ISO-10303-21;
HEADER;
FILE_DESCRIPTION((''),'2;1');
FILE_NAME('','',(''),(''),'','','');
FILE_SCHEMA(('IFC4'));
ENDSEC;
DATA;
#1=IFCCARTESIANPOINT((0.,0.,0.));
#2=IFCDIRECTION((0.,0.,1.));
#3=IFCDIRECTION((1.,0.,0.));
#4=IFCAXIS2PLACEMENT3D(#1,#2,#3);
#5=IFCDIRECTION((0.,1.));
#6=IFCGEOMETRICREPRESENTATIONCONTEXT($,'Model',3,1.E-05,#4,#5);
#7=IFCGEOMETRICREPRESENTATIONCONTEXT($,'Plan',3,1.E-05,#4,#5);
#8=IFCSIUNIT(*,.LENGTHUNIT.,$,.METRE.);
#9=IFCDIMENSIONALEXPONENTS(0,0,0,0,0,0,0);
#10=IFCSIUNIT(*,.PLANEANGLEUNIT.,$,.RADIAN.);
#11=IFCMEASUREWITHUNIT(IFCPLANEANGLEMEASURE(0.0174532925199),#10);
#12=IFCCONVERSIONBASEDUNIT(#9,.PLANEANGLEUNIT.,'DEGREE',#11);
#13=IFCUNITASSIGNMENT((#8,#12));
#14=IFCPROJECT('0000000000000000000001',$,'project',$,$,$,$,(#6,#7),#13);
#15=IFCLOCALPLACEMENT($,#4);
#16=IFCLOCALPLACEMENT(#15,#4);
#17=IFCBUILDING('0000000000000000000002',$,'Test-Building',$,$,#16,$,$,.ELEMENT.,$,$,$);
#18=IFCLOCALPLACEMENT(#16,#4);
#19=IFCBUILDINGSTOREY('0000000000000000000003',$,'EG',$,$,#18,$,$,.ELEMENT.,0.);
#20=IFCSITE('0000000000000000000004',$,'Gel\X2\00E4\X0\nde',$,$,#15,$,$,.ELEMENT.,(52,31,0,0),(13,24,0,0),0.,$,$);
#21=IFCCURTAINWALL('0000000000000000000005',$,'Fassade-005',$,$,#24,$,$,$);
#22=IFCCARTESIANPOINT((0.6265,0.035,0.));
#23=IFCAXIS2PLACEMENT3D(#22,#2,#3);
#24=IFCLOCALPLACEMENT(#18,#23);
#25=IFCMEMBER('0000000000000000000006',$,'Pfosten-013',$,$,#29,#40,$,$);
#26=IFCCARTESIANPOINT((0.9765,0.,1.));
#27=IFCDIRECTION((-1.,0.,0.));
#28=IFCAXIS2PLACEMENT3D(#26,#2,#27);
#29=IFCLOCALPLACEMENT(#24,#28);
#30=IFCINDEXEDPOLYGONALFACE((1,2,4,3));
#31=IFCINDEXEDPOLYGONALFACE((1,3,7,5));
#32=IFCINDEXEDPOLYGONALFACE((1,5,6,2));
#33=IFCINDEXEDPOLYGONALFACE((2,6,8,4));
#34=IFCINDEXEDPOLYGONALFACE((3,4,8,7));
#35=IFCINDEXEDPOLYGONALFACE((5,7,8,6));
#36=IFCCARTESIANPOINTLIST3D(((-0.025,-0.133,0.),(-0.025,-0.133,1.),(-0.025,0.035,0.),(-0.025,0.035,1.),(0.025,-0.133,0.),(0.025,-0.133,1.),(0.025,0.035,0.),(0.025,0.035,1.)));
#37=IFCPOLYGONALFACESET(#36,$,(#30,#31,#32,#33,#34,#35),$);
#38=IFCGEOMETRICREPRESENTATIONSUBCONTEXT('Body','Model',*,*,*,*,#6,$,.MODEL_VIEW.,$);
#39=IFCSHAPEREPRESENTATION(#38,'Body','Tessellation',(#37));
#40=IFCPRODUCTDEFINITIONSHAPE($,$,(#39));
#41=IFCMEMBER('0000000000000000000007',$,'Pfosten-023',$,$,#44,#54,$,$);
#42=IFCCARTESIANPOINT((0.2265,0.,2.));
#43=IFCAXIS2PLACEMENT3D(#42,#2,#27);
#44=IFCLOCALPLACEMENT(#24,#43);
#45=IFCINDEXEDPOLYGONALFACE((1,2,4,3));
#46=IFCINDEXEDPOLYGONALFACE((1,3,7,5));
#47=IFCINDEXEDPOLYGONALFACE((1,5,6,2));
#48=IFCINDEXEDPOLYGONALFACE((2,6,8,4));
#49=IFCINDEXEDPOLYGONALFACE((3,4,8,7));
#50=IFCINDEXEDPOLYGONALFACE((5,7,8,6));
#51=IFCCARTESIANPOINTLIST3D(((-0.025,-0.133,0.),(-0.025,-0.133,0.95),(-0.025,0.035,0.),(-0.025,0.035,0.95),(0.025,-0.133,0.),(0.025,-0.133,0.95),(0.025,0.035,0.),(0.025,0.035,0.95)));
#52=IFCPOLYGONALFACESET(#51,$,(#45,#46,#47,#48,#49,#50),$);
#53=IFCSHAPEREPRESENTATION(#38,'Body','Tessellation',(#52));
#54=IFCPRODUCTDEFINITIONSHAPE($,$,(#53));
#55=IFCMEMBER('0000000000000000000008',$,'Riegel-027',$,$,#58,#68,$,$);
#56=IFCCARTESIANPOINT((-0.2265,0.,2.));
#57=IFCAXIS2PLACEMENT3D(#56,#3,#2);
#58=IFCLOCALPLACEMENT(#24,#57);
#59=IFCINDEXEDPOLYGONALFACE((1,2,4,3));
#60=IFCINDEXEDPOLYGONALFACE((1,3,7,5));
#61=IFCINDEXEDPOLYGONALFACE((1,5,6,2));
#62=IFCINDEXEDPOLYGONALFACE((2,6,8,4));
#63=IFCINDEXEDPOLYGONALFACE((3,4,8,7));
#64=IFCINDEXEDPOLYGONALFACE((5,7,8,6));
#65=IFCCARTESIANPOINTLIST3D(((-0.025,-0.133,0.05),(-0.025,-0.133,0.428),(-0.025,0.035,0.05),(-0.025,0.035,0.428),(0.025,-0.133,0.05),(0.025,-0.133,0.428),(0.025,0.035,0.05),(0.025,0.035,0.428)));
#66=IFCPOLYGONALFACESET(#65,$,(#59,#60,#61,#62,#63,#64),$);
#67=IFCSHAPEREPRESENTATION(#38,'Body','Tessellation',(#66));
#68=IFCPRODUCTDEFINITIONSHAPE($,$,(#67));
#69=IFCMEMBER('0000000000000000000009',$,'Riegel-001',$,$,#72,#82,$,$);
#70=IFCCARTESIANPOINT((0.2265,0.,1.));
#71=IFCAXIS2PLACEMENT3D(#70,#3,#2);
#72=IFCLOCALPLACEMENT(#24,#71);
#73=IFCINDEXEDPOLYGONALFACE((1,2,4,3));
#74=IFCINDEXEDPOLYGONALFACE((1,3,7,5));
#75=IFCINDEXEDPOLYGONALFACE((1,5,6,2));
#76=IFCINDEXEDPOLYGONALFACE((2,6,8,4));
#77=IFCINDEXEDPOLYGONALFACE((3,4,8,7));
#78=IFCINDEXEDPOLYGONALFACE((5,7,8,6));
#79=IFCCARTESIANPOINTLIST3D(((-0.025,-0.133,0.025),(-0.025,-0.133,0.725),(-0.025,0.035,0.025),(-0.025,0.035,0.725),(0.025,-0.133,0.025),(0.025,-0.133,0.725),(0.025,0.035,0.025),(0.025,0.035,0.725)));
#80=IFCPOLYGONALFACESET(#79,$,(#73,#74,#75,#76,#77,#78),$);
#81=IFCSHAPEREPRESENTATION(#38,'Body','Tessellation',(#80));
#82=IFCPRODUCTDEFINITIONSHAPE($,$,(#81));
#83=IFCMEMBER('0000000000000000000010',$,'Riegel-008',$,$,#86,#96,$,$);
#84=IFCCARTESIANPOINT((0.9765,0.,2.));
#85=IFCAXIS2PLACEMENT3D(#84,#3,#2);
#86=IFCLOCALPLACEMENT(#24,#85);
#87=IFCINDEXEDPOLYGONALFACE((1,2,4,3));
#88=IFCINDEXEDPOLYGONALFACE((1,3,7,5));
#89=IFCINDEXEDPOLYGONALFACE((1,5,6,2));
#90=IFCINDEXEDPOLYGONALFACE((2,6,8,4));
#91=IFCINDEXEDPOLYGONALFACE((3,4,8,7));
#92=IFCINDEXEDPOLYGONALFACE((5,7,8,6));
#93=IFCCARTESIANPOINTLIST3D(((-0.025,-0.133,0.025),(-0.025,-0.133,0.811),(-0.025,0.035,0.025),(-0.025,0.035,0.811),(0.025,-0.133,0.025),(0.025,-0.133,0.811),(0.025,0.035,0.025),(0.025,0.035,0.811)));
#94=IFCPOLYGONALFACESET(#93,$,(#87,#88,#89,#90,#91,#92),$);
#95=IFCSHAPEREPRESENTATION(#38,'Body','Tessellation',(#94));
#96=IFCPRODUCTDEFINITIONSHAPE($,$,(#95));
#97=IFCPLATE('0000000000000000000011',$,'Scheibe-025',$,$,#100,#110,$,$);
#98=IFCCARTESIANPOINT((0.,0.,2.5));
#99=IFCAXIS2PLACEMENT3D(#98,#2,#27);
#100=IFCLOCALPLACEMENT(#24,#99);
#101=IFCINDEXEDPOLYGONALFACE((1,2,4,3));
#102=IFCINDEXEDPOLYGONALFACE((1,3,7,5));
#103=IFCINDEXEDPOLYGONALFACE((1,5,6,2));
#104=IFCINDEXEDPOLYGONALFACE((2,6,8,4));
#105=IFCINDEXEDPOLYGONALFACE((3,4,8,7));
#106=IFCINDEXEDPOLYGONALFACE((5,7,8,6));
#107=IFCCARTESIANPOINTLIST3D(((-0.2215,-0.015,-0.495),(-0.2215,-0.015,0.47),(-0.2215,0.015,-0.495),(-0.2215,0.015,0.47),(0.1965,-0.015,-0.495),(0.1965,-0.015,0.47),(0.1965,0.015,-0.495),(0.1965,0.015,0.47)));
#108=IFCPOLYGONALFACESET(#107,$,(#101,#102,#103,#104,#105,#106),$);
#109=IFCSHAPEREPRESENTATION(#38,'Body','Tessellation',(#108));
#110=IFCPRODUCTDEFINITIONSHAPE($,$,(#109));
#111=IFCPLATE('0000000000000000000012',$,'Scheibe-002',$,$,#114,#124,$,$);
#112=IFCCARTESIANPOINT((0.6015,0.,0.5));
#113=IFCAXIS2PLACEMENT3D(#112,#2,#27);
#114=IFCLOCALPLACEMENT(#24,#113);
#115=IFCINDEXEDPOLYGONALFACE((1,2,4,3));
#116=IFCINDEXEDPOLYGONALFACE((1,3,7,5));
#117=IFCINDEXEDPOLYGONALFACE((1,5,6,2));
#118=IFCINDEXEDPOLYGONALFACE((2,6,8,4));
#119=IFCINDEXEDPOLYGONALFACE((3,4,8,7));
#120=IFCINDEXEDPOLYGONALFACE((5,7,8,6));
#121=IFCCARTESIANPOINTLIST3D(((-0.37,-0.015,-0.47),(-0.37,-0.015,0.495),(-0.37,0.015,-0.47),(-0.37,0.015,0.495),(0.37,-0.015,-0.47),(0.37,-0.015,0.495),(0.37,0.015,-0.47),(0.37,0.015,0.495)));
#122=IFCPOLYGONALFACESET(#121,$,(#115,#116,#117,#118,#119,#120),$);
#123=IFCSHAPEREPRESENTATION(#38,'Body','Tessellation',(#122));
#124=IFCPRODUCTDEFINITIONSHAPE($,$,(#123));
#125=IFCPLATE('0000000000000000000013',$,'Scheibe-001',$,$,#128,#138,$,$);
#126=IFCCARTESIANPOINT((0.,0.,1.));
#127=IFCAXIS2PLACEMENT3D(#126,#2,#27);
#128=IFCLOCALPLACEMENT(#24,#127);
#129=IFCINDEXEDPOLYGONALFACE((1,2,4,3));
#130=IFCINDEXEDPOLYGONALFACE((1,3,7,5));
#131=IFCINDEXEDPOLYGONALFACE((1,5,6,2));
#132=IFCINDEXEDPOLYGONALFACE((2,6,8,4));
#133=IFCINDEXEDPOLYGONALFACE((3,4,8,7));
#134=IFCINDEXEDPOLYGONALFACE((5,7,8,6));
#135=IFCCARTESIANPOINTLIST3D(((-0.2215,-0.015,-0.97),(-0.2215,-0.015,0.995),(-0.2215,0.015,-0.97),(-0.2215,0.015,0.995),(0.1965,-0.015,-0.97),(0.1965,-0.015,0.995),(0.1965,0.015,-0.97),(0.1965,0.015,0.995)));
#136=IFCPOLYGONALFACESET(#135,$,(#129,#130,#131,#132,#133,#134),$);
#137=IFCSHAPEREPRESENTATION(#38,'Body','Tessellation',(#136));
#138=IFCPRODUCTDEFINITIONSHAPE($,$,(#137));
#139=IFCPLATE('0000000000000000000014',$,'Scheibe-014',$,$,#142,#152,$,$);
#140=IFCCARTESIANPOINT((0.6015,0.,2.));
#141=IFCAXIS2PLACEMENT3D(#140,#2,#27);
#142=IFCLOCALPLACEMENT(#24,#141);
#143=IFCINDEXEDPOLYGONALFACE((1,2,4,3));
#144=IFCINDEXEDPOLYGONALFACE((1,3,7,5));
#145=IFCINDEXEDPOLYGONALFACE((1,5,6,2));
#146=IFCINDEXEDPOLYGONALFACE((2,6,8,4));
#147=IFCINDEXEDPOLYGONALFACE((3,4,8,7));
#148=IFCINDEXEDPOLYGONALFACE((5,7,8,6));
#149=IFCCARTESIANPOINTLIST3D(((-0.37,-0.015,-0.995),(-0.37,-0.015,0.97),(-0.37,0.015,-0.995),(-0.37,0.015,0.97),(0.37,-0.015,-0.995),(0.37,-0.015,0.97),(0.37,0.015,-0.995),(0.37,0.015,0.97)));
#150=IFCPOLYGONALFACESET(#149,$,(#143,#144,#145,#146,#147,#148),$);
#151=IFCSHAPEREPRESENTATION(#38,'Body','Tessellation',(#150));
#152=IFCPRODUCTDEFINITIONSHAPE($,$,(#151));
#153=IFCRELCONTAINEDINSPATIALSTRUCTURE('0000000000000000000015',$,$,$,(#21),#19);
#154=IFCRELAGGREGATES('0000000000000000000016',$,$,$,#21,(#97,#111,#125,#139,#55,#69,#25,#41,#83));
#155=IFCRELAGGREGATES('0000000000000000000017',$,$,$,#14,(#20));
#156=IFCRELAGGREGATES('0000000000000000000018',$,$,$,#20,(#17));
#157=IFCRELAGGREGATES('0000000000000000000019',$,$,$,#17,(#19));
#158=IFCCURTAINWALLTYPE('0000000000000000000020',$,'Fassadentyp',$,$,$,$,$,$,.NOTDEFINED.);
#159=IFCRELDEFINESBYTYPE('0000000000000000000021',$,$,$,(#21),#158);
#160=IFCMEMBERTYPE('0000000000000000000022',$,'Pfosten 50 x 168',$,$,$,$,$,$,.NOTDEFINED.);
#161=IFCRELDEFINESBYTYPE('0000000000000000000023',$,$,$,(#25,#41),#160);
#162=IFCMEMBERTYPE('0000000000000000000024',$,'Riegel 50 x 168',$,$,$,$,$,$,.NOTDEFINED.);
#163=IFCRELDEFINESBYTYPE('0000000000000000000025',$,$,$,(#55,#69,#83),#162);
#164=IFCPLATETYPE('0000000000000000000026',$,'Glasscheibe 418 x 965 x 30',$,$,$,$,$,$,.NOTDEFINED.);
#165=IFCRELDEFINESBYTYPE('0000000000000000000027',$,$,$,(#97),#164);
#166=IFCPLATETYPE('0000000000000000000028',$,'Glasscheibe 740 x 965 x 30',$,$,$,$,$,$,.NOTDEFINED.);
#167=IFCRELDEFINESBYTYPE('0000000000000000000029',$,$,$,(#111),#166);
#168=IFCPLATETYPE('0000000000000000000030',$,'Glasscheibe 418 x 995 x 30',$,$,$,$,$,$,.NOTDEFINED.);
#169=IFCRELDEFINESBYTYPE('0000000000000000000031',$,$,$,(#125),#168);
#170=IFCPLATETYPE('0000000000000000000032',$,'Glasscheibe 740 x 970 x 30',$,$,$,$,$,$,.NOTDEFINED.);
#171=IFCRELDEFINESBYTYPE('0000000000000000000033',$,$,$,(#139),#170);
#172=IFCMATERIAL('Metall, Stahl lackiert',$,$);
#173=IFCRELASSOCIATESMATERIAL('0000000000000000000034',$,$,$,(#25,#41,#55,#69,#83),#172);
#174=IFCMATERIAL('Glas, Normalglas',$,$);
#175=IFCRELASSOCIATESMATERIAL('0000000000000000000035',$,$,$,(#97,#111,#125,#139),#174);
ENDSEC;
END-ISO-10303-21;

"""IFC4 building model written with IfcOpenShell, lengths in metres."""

from ifc_helpers import new_model, entity, si_unit, converted_unit, direction, frame, origin_with_axes, place, context, subcontext, project, spatial, polyline, outline, extrude, material, type_object, element, aggregate, save


model = new_model("IFC4")

# Units and contexts
model_context = context("Model", 3, precision=1e-05, world=origin_with_axes(), true_north=direction((0.0, 1.0)))
plan_context = context("Plan", 3, precision=1e-05, world=origin_with_axes(), true_north=direction((0.0, 1.0)))
body_context = subcontext(model_context, "Body", "Model", "MODEL_VIEW")
ifc_project = project(units=[si_unit("LENGTHUNIT", "METRE"), converted_unit("PLANEANGLEUNIT", "DEGREE", entity("IfcPlaneAngleMeasure", 0.0174532925199), si_unit("PLANEANGLEUNIT", "RADIAN"), dimensions=[0, 0, 0, 0, 0, 0, 0])], contexts=[model_context, plan_context])

# Site, building, storey
site_placement = place(None, origin_with_axes())
site = spatial("IfcSite", under=ifc_project, at=site_placement, Name="Gelände", CompositionType="ELEMENT", RefLatitude=(52, 31, 0, 0), RefLongitude=(13, 24, 0, 0), RefElevation=0.0)
building_placement = place(site_placement, origin_with_axes())
building = spatial("IfcBuilding", under=site, at=building_placement, Name="Test-Building", CompositionType="ELEMENT")
storey_placement = place(building_placement, origin_with_axes())
storey = spatial("IfcBuildingStorey", under=building, at=storey_placement, Name="EG", CompositionType="ELEMENT", Elevation=0.0)

# Curtain wall, members, plates
curtain_wall_type = type_object("IfcCurtainWallType", Name="Fassadentyp", PredefinedType="NOTDEFINED")
curtain_wall_placement = place(storey_placement, frame((0.6265, 0.035, 0.0), z_axis=(0.0, 0.0, 1.0), x_axis=(1.0, 0.0, 0.0)))
curtain_wall = element("IfcCurtainWall", 1, at=curtain_wall_placement, inside=storey, type_object=curtain_wall_type, Name="Fassade-005")
ifc_material_1 = material(Name="Metall, Stahl lackiert")
member_type_1 = type_object("IfcMemberType", Name="Pfosten 50 x 168", PredefinedType="NOTDEFINED")
member_1_placement = place(curtain_wall_placement, frame((0.9765, 0.0, 1.0), z_axis=(0.0, 0.0, 1.0), x_axis=(-1.0, 0.0, 0.0)))
member_1 = element("IfcMember", 2, at=member_1_placement, type_object=member_type_1, material=ifc_material_1, Name="Pfosten-013", context=body_context, shape_type="SweptSolid", body=[
    extrude(outline(polyline([(-0.025, 0.133), (-0.025, -0.035), (0.025, -0.035), (0.025, 0.133), (-0.025, 0.133)])), frame((0.0, 0.0, 0.0), z_axis=(0.0, 0.0, 1.0), x_axis=(-1.0, 0.0, 0.0)), (0.0, 0.0, 1.0), 1.0),
])
member_2_placement = place(curtain_wall_placement, frame((0.2265, 0.0, 2.0), z_axis=(0.0, 0.0, 1.0), x_axis=(-1.0, 0.0, 0.0)))
member_2 = element("IfcMember", 3, at=member_2_placement, type_object=member_type_1, material=ifc_material_1, Name="Pfosten-023", context=body_context, shape_type="SweptSolid", body=[
    extrude(outline(polyline([(-0.025, 0.133), (-0.025, -0.035), (0.025, -0.035), (0.025, 0.133), (-0.025, 0.133)])), frame((0.0, 0.0, 0.0), z_axis=(0.0, 0.0, 1.0), x_axis=(-1.0, 0.0, 0.0)), (0.0, 0.0, 1.0), 0.95),
])
member_type_2 = type_object("IfcMemberType", Name="Riegel 50 x 168", PredefinedType="NOTDEFINED")
member_3_placement = place(curtain_wall_placement, frame((-0.2265, 0.0, 2.0), z_axis=(1.0, 0.0, 0.0), x_axis=(0.0, 0.0, 1.0)))
member_3 = element("IfcMember", 4, at=member_3_placement, type_object=member_type_2, material=ifc_material_1, Name="Riegel-027", context=body_context, shape_type="SweptSolid", body=[
    extrude(outline(polyline([(-0.133, -0.025), (0.035, -0.025), (0.035, 0.025), (-0.133, 0.025), (-0.133, -0.025)])), frame((0.0, 0.0, 0.05), z_axis=(0.0, 0.0, 1.0), x_axis=(0.0, 1.0, 0.0)), (0.0, 0.0, 1.0), 0.378),
])
member_4_placement = place(curtain_wall_placement, frame((0.2265, 0.0, 1.0), z_axis=(1.0, 0.0, 0.0), x_axis=(0.0, 0.0, 1.0)))
member_4 = element("IfcMember", 5, at=member_4_placement, type_object=member_type_2, material=ifc_material_1, Name="Riegel-001", context=body_context, shape_type="SweptSolid", body=[
    extrude(outline(polyline([(-0.133, -0.025), (0.035, -0.025), (0.035, 0.025), (-0.133, 0.025), (-0.133, -0.025)])), frame((0.0, 0.0, 0.025), z_axis=(0.0, 0.0, 1.0), x_axis=(0.0, 1.0, 0.0)), (0.0, 0.0, 1.0), 0.7),
])
member_5_placement = place(curtain_wall_placement, frame((0.9765, 0.0, 2.0), z_axis=(1.0, 0.0, 0.0), x_axis=(0.0, 0.0, 1.0)))
member_5 = element("IfcMember", 6, at=member_5_placement, type_object=member_type_2, material=ifc_material_1, Name="Riegel-008", context=body_context, shape_type="SweptSolid", body=[
    extrude(outline(polyline([(-0.133, -0.025), (0.035, -0.025), (0.035, 0.025), (-0.133, 0.025), (-0.133, -0.025)])), frame((0.0, 0.0, 0.025), z_axis=(0.0, 0.0, 1.0), x_axis=(0.0, 1.0, 0.0)), (0.0, 0.0, 1.0), 0.786),
])
ifc_material_2 = material(Name="Glas, Normalglas")
plate_type_1 = type_object("IfcPlateType", Name="Glasscheibe 418 x 965 x 30", PredefinedType="NOTDEFINED")
plate_1_placement = place(curtain_wall_placement, frame((0.0, 0.0, 2.5), z_axis=(0.0, 0.0, 1.0), x_axis=(-1.0, 0.0, 0.0)))
plate_1 = element("IfcPlate", 7, at=plate_1_placement, type_object=plate_type_1, material=ifc_material_2, Name="Scheibe-025", context=body_context, shape_type="SweptSolid", body=[
    extrude(outline(polyline([(-0.2215, -0.47), (0.1965, -0.47), (0.1965, 0.495), (-0.2215, 0.495), (-0.2215, -0.47)])), frame((0.0, -0.015, 0.0), z_axis=(0.0, 1.0, 0.0), x_axis=(1.0, 0.0, 0.0)), (0.0, 0.0, 1.0), 0.03),
])
plate_type_2 = type_object("IfcPlateType", Name="Glasscheibe 740 x 965 x 30", PredefinedType="NOTDEFINED")
plate_2_placement = place(curtain_wall_placement, frame((0.6015, 0.0, 0.5), z_axis=(0.0, 0.0, 1.0), x_axis=(-1.0, 0.0, 0.0)))
plate_2 = element("IfcPlate", 8, at=plate_2_placement, type_object=plate_type_2, material=ifc_material_2, Name="Scheibe-002", context=body_context, shape_type="SweptSolid", body=[
    extrude(outline(polyline([(-0.37, -0.495), (0.37, -0.495), (0.37, 0.47), (-0.37, 0.47), (-0.37, -0.495)])), frame((0.0, -0.015, 0.0), z_axis=(0.0, 1.0, 0.0), x_axis=(1.0, 0.0, 0.0)), (0.0, 0.0, 1.0), 0.03),
])
plate_type_3 = type_object("IfcPlateType", Name="Glasscheibe 418 x 995 x 30", PredefinedType="NOTDEFINED")
plate_3_placement = place(curtain_wall_placement, frame((0.0, 0.0, 1.0), z_axis=(0.0, 0.0, 1.0), x_axis=(-1.0, 0.0, 0.0)))
plate_3 = element("IfcPlate", 9, at=plate_3_placement, type_object=plate_type_3, material=ifc_material_2, Name="Scheibe-001", context=body_context, shape_type="SweptSolid", body=[
    extrude(outline(polyline([(-0.2215, -0.995), (0.1965, -0.995), (0.1965, 0.97), (-0.2215, 0.97), (-0.2215, -0.995)])), frame((0.0, -0.015, 0.0), z_axis=(0.0, 1.0, 0.0), x_axis=(1.0, 0.0, 0.0)), (0.0, 0.0, 1.0), 0.03),
])
plate_type_4 = type_object("IfcPlateType", Name="Glasscheibe 740 x 970 x 30", PredefinedType="NOTDEFINED")
plate_4_placement = place(curtain_wall_placement, frame((0.6015, 0.0, 2.0), z_axis=(0.0, 0.0, 1.0), x_axis=(-1.0, 0.0, 0.0)))
plate_4 = element("IfcPlate", 10, at=plate_4_placement, type_object=plate_type_4, material=ifc_material_2, Name="Scheibe-014", context=body_context, shape_type="SweptSolid", body=[
    extrude(outline(polyline([(-0.37, -0.97), (0.37, -0.97), (0.37, 0.995), (-0.37, 0.995), (-0.37, -0.97)])), frame((0.0, -0.015, 0.0), z_axis=(0.0, 1.0, 0.0), x_axis=(1.0, 0.0, 0.0)), (0.0, 0.0, 1.0), 0.03),
])
aggregate(curtain_wall, [plate_1, plate_2, plate_3, plate_4, member_3, member_4, member_1, member_2, member_5])

save(model, "model.ifc")
